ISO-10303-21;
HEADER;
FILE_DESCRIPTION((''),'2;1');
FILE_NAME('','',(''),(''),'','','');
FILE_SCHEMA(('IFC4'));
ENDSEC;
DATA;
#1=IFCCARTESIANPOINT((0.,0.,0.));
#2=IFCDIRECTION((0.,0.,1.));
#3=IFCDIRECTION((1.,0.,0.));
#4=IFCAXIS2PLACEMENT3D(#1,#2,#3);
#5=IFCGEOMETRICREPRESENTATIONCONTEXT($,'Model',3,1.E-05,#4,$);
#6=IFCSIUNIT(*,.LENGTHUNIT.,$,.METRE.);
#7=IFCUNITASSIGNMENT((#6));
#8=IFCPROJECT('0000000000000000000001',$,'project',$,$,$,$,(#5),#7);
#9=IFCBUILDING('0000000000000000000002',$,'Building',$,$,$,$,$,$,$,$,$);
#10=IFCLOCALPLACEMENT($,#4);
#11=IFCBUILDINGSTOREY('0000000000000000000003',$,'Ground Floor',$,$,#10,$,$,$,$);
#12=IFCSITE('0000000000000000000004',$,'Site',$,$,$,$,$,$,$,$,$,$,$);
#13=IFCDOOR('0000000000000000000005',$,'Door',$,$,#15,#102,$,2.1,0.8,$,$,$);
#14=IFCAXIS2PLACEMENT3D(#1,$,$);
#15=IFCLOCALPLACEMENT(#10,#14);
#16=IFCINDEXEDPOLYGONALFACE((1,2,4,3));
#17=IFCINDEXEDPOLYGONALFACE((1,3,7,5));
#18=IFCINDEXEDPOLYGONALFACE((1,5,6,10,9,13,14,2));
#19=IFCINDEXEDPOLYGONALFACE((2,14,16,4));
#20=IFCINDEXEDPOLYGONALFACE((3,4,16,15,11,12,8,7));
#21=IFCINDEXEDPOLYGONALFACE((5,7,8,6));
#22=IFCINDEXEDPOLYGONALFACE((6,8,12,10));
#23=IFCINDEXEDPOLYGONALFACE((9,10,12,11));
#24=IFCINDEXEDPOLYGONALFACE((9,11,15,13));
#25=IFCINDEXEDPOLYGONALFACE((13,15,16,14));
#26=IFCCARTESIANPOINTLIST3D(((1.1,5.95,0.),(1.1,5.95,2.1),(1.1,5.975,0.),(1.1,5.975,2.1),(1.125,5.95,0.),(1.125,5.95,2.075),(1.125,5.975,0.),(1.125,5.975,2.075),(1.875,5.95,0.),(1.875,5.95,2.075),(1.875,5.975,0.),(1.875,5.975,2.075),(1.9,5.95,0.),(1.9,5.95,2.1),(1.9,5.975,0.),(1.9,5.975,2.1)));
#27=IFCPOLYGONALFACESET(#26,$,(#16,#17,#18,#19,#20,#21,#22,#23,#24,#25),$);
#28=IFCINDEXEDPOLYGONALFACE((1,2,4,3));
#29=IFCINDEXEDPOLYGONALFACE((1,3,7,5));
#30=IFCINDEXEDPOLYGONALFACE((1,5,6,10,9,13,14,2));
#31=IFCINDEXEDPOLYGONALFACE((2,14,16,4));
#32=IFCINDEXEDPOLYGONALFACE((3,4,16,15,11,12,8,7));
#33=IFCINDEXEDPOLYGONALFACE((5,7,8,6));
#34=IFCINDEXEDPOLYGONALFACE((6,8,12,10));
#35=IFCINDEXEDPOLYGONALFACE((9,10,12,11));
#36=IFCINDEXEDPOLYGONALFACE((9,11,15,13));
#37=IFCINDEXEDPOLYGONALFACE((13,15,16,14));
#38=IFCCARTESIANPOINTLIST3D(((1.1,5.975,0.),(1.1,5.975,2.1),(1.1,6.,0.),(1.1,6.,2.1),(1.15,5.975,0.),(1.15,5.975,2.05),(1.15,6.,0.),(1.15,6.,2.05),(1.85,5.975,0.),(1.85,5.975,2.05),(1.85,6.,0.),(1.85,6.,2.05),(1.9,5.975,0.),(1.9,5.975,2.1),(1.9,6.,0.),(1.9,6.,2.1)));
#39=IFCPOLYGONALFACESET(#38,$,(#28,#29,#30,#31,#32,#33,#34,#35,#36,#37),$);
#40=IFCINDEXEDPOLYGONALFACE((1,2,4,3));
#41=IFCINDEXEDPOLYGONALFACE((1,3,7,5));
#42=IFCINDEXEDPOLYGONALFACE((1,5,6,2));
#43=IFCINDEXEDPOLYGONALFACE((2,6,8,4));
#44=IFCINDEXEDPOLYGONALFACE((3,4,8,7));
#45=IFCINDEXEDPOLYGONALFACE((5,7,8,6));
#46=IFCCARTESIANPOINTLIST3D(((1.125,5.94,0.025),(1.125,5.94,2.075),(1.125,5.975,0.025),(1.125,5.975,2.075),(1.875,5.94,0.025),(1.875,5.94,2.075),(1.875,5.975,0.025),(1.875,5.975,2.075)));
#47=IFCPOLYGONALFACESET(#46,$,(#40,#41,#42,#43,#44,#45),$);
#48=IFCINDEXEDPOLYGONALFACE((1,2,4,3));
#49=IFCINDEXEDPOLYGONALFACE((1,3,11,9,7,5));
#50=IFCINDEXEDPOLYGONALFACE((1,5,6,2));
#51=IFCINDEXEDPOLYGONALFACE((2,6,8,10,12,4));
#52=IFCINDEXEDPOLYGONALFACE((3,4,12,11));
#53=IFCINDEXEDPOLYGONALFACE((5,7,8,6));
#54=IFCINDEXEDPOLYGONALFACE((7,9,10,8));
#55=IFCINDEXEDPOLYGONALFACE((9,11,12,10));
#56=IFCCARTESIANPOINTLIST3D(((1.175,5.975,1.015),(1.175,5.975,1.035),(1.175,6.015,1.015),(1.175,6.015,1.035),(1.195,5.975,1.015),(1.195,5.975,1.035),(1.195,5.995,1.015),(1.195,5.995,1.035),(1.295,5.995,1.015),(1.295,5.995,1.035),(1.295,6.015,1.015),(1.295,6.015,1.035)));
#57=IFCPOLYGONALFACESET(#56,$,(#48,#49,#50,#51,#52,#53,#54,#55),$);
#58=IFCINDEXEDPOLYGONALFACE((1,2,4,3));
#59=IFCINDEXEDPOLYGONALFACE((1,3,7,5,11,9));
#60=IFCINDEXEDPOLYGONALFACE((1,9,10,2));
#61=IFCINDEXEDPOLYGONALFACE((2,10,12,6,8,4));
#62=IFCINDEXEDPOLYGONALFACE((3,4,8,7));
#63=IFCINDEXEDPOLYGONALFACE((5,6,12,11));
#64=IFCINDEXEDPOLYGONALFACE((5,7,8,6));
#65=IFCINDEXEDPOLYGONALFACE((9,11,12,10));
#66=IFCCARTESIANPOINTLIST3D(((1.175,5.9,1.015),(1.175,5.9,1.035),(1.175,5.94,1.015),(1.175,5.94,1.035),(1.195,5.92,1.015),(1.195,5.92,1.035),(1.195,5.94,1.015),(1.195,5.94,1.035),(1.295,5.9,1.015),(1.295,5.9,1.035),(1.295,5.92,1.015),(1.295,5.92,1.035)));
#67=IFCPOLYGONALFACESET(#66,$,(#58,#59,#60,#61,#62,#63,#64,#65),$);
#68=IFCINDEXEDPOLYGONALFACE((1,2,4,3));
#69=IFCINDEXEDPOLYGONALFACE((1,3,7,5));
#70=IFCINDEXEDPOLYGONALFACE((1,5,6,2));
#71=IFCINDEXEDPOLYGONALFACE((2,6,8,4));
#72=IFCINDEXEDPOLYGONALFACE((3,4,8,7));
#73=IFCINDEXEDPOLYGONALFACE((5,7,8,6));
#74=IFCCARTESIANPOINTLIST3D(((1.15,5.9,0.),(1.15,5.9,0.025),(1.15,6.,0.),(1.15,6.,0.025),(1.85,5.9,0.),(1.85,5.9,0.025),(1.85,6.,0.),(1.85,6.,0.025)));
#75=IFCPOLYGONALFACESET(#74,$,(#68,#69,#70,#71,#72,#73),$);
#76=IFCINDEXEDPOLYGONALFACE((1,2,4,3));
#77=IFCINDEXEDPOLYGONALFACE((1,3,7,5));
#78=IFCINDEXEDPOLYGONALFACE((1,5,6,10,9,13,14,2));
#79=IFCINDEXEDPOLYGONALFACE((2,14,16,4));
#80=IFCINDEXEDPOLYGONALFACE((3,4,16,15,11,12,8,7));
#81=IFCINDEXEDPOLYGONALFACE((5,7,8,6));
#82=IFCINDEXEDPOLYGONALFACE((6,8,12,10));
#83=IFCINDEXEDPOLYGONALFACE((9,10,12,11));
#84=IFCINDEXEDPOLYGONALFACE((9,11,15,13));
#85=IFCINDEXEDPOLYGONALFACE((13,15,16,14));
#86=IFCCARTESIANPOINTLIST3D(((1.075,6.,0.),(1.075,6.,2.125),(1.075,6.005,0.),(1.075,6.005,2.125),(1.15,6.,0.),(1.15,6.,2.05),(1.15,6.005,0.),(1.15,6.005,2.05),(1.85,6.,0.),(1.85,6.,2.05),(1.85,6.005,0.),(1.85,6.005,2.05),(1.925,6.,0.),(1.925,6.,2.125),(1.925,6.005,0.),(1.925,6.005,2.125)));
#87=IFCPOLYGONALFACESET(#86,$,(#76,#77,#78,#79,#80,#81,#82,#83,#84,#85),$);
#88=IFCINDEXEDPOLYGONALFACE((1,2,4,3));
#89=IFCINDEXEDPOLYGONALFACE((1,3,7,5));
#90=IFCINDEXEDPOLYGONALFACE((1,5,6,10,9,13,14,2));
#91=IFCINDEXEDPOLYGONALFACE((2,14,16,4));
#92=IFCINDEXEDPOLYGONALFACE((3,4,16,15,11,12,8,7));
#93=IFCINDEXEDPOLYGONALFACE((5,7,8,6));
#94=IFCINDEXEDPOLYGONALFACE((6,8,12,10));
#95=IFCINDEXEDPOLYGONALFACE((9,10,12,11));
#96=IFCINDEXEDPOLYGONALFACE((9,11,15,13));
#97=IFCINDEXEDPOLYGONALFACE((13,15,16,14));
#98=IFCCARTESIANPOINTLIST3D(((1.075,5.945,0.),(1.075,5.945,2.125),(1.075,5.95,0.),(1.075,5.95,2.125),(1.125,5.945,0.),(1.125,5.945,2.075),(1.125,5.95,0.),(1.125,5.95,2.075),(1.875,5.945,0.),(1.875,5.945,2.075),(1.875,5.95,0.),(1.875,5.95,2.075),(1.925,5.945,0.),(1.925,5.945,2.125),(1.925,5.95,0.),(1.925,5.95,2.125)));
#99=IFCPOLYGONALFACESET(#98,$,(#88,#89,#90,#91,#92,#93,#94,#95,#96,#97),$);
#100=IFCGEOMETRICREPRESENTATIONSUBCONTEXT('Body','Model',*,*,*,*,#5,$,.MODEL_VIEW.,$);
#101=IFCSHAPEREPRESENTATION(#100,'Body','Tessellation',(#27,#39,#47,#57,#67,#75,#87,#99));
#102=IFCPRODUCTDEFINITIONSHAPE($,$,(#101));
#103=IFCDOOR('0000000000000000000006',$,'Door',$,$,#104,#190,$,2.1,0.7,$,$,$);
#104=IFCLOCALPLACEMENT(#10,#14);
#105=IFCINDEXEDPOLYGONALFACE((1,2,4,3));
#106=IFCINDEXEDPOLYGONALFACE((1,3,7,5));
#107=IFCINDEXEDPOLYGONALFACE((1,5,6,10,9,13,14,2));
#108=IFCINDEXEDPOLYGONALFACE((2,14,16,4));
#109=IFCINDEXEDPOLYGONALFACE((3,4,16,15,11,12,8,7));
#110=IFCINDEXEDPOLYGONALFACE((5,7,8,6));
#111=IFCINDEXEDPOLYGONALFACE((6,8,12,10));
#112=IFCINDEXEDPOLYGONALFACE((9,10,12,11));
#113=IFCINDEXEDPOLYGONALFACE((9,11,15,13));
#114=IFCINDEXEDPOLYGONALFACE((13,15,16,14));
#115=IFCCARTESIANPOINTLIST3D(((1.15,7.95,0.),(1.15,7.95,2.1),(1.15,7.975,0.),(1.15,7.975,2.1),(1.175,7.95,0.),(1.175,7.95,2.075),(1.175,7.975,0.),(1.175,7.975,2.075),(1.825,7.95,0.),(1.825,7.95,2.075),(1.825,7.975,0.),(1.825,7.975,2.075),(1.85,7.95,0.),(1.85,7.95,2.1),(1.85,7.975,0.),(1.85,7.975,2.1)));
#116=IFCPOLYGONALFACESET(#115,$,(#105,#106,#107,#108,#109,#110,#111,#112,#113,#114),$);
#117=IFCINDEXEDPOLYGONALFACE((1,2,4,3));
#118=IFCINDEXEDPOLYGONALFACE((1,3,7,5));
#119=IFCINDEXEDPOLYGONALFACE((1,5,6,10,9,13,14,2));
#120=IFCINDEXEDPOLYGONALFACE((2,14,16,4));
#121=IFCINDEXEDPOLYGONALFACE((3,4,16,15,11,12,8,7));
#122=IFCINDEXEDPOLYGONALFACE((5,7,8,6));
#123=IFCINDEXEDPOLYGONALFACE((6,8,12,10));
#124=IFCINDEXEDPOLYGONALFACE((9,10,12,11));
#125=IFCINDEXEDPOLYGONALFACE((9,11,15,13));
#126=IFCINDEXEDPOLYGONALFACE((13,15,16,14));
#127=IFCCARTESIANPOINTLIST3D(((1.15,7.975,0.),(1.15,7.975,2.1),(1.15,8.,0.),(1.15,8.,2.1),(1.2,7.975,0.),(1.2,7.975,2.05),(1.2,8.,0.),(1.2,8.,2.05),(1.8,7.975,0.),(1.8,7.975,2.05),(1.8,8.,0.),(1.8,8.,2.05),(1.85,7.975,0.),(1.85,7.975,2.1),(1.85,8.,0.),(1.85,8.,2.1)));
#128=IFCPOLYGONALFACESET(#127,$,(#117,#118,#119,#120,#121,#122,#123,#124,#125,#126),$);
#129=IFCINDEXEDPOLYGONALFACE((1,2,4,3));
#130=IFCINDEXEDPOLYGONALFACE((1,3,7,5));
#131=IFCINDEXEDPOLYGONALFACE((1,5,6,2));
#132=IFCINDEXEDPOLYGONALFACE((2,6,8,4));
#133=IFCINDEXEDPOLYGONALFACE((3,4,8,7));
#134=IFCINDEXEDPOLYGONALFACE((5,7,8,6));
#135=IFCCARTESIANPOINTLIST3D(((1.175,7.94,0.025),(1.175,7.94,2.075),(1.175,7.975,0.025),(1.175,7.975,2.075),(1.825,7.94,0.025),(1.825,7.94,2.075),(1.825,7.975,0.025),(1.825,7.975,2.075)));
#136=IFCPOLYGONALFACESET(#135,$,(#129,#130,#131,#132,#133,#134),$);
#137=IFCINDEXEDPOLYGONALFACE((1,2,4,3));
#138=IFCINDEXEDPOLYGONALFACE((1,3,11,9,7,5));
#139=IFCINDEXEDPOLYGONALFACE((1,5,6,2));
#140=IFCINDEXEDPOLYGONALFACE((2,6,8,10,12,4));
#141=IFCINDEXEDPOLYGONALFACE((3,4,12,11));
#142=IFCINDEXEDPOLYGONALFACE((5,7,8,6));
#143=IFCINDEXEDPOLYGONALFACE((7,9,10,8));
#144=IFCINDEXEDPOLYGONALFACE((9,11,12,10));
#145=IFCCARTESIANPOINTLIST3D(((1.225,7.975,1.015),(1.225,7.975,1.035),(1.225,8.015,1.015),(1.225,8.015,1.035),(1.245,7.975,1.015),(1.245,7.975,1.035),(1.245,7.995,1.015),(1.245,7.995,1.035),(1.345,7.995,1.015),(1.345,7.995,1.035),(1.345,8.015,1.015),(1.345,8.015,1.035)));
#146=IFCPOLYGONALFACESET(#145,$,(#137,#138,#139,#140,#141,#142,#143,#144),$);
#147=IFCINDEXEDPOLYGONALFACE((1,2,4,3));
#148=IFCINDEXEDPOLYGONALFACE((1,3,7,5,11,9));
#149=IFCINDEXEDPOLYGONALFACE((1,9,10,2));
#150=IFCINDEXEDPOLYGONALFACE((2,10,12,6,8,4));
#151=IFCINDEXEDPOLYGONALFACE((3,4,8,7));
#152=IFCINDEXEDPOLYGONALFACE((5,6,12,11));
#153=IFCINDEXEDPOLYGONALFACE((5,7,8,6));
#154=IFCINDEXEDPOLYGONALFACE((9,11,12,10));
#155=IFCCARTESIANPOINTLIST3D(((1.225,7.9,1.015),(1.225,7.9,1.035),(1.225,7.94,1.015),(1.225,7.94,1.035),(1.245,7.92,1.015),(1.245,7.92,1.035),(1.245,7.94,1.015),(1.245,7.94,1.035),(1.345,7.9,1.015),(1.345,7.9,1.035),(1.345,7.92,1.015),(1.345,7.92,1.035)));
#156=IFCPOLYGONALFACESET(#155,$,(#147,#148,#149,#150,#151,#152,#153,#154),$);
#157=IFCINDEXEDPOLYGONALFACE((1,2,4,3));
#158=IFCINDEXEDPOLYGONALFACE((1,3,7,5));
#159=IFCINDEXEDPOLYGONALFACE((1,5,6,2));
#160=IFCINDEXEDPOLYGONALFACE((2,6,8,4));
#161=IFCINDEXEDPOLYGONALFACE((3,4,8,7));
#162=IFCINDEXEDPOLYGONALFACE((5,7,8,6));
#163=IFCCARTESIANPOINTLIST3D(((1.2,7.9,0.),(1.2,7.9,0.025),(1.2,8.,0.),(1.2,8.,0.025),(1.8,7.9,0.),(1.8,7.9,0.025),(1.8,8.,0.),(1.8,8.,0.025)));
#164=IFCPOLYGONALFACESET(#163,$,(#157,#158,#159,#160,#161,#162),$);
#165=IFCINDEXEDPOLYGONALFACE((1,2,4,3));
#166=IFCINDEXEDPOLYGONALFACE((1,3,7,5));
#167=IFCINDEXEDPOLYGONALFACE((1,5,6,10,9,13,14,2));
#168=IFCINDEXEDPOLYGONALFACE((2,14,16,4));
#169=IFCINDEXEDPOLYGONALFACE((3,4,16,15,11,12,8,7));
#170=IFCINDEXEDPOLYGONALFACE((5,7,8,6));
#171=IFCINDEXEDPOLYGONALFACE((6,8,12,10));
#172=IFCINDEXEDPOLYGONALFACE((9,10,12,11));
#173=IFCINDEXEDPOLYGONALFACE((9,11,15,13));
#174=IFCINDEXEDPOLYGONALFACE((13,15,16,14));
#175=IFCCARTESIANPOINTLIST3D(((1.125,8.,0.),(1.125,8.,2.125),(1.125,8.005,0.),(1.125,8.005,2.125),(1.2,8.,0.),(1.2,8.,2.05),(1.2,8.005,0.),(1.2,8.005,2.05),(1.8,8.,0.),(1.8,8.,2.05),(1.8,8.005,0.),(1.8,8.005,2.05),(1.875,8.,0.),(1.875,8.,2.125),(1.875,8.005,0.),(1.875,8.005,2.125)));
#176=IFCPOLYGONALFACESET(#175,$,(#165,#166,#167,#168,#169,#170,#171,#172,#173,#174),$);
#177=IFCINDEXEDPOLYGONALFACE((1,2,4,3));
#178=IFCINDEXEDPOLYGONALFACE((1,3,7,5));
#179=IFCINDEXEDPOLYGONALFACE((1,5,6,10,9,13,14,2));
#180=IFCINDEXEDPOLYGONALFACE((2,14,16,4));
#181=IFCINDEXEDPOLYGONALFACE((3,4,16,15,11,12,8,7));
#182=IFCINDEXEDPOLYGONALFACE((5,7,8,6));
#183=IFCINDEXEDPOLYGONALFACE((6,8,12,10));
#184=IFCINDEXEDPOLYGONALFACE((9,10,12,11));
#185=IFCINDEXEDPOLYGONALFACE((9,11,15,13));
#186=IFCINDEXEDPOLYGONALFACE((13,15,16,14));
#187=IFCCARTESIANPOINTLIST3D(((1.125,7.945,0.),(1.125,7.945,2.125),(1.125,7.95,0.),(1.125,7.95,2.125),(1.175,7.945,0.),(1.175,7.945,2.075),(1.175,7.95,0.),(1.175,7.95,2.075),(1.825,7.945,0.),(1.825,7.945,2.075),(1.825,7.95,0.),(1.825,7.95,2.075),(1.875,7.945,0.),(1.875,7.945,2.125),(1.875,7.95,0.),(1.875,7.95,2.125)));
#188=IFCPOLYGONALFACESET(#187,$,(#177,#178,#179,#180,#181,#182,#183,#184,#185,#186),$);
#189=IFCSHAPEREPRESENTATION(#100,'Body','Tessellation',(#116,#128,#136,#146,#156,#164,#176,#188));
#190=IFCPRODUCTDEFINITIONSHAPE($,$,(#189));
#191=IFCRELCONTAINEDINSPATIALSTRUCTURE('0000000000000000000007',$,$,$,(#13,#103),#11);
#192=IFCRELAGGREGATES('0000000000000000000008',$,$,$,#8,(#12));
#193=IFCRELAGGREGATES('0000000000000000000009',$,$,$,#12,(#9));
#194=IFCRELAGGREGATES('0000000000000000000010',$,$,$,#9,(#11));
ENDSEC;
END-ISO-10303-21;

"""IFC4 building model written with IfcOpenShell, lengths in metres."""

from ifc_helpers import new_model, si_unit, frame, origin_with_axes, place, context, subcontext, project, spatial, line, indexed_curve, outline, extrude, element, save


model = new_model("IFC4")

# Units and contexts
model_context = context("Model", 3, precision=1e-05, world=origin_with_axes())
body_context = subcontext(model_context, "Body", "Model", "MODEL_VIEW")
ifc_project = project(units=[si_unit("LENGTHUNIT", "METRE")], contexts=[model_context])

# Site, building, storey
site = spatial("IfcSite", under=ifc_project, Name="Site")
building = spatial("IfcBuilding", under=site, Name="Building")
storey_placement = place(None, origin_with_axes())
storey = spatial("IfcBuildingStorey", under=building, at=storey_placement, Name="Ground Floor")

# Doors
door_1_placement = place(storey_placement, frame((1.9, 6.0, 0.0), z_axis=(0.0, 0.0, 1.0), x_axis=(-1.0, 0.0, 0.0)))
element("IfcDoor", 1, at=door_1_placement, inside=storey, Name="Door", OverallHeight=2.1, OverallWidth=0.8, context=body_context, shape_type="SweptSolid", body=[
    extrude(outline(indexed_curve([(0.0, 0.0), (0.0, 2.1), (0.8, 2.1), (0.8, 0.0), (0.775, 0.0), (0.775, 2.075), (0.025, 2.075), (0.025, 0.0)], segments=[line(1, 2, 3, 4, 5, 6, 7, 8, 1)])), frame((0.0, 0.025, 0.0), z_axis=(0.0, -1.0, 0.0), x_axis=(1.0, 0.0, 0.0)), (0.0, 0.0, -1.0), 0.025),
    extrude(outline(indexed_curve([(0.0, 0.0), (0.0, 2.1), (0.8, 2.1), (0.8, 0.0), (0.75, 0.0), (0.75, 2.05), (0.05, 2.05), (0.05, 0.0)], segments=[line(1, 2, 3, 4, 5, 6, 7, 8, 1)])), frame((0.0, 0.0, 0.0), z_axis=(0.0, -1.0, 0.0), x_axis=(1.0, 0.0, 0.0)), (0.0, 0.0, -1.0), 0.025),
    extrude(outline(indexed_curve([(0.0, 0.0), (0.75, 0.0), (0.75, 0.035), (0.0, 0.035)], segments=[line(1, 2, 3, 4, 1)])), frame((0.025, 0.025, 0.025), z_axis=(0.0, 0.0, 1.0), x_axis=(1.0, 0.0, 0.0)), (0.0, 0.0, 1.0), 2.05),
    extrude(outline(indexed_curve([(0.0, 0.0), (0.0, -0.04), (-0.12, -0.04), (-0.12, -0.02), (-0.02, -0.02), (-0.02, 0.0)], segments=[line(1, 2, 3, 4, 5, 6, 1)])), frame((0.725, 0.025, 1.015), z_axis=(0.0, 0.0, 1.0), x_axis=(1.0, 0.0, 0.0)), (0.0, 0.0, 1.0), 0.02),
    extrude(outline(indexed_curve([(0.0, 0.0), (0.0, 0.04), (-0.12, 0.04), (-0.12, 0.02), (-0.02, 0.02), (-0.02, 0.0)], segments=[line(1, 2, 3, 4, 5, 6, 1)])), frame((0.725, 0.06, 1.015), z_axis=(0.0, 0.0, 1.0), x_axis=(1.0, 0.0, 0.0)), (0.0, 0.0, 1.0), 0.02),
    extrude(outline(indexed_curve([(0.0, 0.0), (0.7, 0.0), (0.7, 0.1), (0.0, 0.1)], segments=[line(1, 2, 3, 4, 1)])), frame((0.05, 0.0, 0.0), z_axis=(0.0, 0.0, 1.0), x_axis=(1.0, 0.0, 0.0)), (0.0, 0.0, 1.0), 0.025),
    extrude(outline(indexed_curve([(0.0, 0.0), (0.0, 2.125), (0.85, 2.125), (0.85, 0.0), (0.775, 0.0), (0.775, 2.05), (0.075, 2.05), (0.075, 0.0)], segments=[line(1, 2, 3, 4, 5, 6, 7, 8, 1)])), frame((-0.025, -0.005, 0.0), z_axis=(0.0, -1.0, 0.0), x_axis=(1.0, 0.0, 0.0)), (0.0, 0.0, -1.0), 0.005),
    extrude(outline(indexed_curve([(0.0, 0.0), (0.0, 2.125), (0.85, 2.125), (0.85, 0.0), (0.8, 0.0), (0.8, 2.075), (0.05, 2.075), (0.05, 0.0)], segments=[line(1, 2, 3, 4, 5, 6, 7, 8, 1)])), frame((-0.025, 0.05, 0.0), z_axis=(0.0, -1.0, 0.0), x_axis=(1.0, 0.0, 0.0)), (0.0, 0.0, -1.0), 0.005),
])
door_2_placement = place(storey_placement, frame((1.85, 8.0, 0.0), z_axis=(0.0, 0.0, 1.0), x_axis=(-1.0, 0.0, 0.0)))
element("IfcDoor", 2, at=door_2_placement, inside=storey, Name="Door", OverallHeight=2.1, OverallWidth=0.7, context=body_context, shape_type="SweptSolid", body=[
    extrude(outline(indexed_curve([(0.0, 0.0), (0.0, 2.1), (0.7, 2.1), (0.7, 0.0), (0.675, 0.0), (0.675, 2.075), (0.025, 2.075), (0.025, 0.0)], segments=[line(1, 2, 3, 4, 5, 6, 7, 8, 1)])), frame((0.0, 0.025, 0.0), z_axis=(0.0, -1.0, 0.0), x_axis=(1.0, 0.0, 0.0)), (0.0, 0.0, -1.0), 0.025),
    extrude(outline(indexed_curve([(0.0, 0.0), (0.0, 2.1), (0.7, 2.1), (0.7, 0.0), (0.65, 0.0), (0.65, 2.05), (0.05, 2.05), (0.05, 0.0)], segments=[line(1, 2, 3, 4, 5, 6, 7, 8, 1)])), frame((0.0, 0.0, 0.0), z_axis=(0.0, -1.0, 0.0), x_axis=(1.0, 0.0, 0.0)), (0.0, 0.0, -1.0), 0.025),
    extrude(outline(indexed_curve([(0.0, 0.0), (0.65, 0.0), (0.65, 0.035), (0.0, 0.035)], segments=[line(1, 2, 3, 4, 1)])), frame((0.025, 0.025, 0.025), z_axis=(0.0, 0.0, 1.0), x_axis=(1.0, 0.0, 0.0)), (0.0, 0.0, 1.0), 2.05),
    extrude(outline(indexed_curve([(0.0, 0.0), (0.0, -0.04), (-0.12, -0.04), (-0.12, -0.02), (-0.02, -0.02), (-0.02, 0.0)], segments=[line(1, 2, 3, 4, 5, 6, 1)])), frame((0.625, 0.025, 1.015), z_axis=(0.0, 0.0, 1.0), x_axis=(1.0, 0.0, 0.0)), (0.0, 0.0, 1.0), 0.02),
    extrude(outline(indexed_curve([(0.0, 0.0), (0.0, 0.04), (-0.12, 0.04), (-0.12, 0.02), (-0.02, 0.02), (-0.02, 0.0)], segments=[line(1, 2, 3, 4, 5, 6, 1)])), frame((0.625, 0.06, 1.015), z_axis=(0.0, 0.0, 1.0), x_axis=(1.0, 0.0, 0.0)), (0.0, 0.0, 1.0), 0.02),
    extrude(outline(indexed_curve([(0.0, 0.0), (0.6, 0.0), (0.6, 0.1), (0.0, 0.1)], segments=[line(1, 2, 3, 4, 1)])), frame((0.05, 0.0, 0.0), z_axis=(0.0, 0.0, 1.0), x_axis=(1.0, 0.0, 0.0)), (0.0, 0.0, 1.0), 0.025),
    extrude(outline(indexed_curve([(0.0, 0.0), (0.0, 2.125), (0.75, 2.125), (0.75, 0.0), (0.675, 0.0), (0.675, 2.05), (0.075, 2.05), (0.075, 0.0)], segments=[line(1, 2, 3, 4, 5, 6, 7, 8, 1)])), frame((-0.025, -0.005, 0.0), z_axis=(0.0, -1.0, 0.0), x_axis=(1.0, 0.0, 0.0)), (0.0, 0.0, -1.0), 0.005),
    extrude(outline(indexed_curve([(0.0, 0.0), (0.0, 2.125), (0.75, 2.125), (0.75, 0.0), (0.7, 0.0), (0.7, 2.075), (0.05, 2.075), (0.05, 0.0)], segments=[line(1, 2, 3, 4, 5, 6, 7, 8, 1)])), frame((-0.025, 0.05, 0.0), z_axis=(0.0, -1.0, 0.0), x_axis=(1.0, 0.0, 0.0)), (0.0, 0.0, -1.0), 0.005),
])

save(model, "model.ifc")
